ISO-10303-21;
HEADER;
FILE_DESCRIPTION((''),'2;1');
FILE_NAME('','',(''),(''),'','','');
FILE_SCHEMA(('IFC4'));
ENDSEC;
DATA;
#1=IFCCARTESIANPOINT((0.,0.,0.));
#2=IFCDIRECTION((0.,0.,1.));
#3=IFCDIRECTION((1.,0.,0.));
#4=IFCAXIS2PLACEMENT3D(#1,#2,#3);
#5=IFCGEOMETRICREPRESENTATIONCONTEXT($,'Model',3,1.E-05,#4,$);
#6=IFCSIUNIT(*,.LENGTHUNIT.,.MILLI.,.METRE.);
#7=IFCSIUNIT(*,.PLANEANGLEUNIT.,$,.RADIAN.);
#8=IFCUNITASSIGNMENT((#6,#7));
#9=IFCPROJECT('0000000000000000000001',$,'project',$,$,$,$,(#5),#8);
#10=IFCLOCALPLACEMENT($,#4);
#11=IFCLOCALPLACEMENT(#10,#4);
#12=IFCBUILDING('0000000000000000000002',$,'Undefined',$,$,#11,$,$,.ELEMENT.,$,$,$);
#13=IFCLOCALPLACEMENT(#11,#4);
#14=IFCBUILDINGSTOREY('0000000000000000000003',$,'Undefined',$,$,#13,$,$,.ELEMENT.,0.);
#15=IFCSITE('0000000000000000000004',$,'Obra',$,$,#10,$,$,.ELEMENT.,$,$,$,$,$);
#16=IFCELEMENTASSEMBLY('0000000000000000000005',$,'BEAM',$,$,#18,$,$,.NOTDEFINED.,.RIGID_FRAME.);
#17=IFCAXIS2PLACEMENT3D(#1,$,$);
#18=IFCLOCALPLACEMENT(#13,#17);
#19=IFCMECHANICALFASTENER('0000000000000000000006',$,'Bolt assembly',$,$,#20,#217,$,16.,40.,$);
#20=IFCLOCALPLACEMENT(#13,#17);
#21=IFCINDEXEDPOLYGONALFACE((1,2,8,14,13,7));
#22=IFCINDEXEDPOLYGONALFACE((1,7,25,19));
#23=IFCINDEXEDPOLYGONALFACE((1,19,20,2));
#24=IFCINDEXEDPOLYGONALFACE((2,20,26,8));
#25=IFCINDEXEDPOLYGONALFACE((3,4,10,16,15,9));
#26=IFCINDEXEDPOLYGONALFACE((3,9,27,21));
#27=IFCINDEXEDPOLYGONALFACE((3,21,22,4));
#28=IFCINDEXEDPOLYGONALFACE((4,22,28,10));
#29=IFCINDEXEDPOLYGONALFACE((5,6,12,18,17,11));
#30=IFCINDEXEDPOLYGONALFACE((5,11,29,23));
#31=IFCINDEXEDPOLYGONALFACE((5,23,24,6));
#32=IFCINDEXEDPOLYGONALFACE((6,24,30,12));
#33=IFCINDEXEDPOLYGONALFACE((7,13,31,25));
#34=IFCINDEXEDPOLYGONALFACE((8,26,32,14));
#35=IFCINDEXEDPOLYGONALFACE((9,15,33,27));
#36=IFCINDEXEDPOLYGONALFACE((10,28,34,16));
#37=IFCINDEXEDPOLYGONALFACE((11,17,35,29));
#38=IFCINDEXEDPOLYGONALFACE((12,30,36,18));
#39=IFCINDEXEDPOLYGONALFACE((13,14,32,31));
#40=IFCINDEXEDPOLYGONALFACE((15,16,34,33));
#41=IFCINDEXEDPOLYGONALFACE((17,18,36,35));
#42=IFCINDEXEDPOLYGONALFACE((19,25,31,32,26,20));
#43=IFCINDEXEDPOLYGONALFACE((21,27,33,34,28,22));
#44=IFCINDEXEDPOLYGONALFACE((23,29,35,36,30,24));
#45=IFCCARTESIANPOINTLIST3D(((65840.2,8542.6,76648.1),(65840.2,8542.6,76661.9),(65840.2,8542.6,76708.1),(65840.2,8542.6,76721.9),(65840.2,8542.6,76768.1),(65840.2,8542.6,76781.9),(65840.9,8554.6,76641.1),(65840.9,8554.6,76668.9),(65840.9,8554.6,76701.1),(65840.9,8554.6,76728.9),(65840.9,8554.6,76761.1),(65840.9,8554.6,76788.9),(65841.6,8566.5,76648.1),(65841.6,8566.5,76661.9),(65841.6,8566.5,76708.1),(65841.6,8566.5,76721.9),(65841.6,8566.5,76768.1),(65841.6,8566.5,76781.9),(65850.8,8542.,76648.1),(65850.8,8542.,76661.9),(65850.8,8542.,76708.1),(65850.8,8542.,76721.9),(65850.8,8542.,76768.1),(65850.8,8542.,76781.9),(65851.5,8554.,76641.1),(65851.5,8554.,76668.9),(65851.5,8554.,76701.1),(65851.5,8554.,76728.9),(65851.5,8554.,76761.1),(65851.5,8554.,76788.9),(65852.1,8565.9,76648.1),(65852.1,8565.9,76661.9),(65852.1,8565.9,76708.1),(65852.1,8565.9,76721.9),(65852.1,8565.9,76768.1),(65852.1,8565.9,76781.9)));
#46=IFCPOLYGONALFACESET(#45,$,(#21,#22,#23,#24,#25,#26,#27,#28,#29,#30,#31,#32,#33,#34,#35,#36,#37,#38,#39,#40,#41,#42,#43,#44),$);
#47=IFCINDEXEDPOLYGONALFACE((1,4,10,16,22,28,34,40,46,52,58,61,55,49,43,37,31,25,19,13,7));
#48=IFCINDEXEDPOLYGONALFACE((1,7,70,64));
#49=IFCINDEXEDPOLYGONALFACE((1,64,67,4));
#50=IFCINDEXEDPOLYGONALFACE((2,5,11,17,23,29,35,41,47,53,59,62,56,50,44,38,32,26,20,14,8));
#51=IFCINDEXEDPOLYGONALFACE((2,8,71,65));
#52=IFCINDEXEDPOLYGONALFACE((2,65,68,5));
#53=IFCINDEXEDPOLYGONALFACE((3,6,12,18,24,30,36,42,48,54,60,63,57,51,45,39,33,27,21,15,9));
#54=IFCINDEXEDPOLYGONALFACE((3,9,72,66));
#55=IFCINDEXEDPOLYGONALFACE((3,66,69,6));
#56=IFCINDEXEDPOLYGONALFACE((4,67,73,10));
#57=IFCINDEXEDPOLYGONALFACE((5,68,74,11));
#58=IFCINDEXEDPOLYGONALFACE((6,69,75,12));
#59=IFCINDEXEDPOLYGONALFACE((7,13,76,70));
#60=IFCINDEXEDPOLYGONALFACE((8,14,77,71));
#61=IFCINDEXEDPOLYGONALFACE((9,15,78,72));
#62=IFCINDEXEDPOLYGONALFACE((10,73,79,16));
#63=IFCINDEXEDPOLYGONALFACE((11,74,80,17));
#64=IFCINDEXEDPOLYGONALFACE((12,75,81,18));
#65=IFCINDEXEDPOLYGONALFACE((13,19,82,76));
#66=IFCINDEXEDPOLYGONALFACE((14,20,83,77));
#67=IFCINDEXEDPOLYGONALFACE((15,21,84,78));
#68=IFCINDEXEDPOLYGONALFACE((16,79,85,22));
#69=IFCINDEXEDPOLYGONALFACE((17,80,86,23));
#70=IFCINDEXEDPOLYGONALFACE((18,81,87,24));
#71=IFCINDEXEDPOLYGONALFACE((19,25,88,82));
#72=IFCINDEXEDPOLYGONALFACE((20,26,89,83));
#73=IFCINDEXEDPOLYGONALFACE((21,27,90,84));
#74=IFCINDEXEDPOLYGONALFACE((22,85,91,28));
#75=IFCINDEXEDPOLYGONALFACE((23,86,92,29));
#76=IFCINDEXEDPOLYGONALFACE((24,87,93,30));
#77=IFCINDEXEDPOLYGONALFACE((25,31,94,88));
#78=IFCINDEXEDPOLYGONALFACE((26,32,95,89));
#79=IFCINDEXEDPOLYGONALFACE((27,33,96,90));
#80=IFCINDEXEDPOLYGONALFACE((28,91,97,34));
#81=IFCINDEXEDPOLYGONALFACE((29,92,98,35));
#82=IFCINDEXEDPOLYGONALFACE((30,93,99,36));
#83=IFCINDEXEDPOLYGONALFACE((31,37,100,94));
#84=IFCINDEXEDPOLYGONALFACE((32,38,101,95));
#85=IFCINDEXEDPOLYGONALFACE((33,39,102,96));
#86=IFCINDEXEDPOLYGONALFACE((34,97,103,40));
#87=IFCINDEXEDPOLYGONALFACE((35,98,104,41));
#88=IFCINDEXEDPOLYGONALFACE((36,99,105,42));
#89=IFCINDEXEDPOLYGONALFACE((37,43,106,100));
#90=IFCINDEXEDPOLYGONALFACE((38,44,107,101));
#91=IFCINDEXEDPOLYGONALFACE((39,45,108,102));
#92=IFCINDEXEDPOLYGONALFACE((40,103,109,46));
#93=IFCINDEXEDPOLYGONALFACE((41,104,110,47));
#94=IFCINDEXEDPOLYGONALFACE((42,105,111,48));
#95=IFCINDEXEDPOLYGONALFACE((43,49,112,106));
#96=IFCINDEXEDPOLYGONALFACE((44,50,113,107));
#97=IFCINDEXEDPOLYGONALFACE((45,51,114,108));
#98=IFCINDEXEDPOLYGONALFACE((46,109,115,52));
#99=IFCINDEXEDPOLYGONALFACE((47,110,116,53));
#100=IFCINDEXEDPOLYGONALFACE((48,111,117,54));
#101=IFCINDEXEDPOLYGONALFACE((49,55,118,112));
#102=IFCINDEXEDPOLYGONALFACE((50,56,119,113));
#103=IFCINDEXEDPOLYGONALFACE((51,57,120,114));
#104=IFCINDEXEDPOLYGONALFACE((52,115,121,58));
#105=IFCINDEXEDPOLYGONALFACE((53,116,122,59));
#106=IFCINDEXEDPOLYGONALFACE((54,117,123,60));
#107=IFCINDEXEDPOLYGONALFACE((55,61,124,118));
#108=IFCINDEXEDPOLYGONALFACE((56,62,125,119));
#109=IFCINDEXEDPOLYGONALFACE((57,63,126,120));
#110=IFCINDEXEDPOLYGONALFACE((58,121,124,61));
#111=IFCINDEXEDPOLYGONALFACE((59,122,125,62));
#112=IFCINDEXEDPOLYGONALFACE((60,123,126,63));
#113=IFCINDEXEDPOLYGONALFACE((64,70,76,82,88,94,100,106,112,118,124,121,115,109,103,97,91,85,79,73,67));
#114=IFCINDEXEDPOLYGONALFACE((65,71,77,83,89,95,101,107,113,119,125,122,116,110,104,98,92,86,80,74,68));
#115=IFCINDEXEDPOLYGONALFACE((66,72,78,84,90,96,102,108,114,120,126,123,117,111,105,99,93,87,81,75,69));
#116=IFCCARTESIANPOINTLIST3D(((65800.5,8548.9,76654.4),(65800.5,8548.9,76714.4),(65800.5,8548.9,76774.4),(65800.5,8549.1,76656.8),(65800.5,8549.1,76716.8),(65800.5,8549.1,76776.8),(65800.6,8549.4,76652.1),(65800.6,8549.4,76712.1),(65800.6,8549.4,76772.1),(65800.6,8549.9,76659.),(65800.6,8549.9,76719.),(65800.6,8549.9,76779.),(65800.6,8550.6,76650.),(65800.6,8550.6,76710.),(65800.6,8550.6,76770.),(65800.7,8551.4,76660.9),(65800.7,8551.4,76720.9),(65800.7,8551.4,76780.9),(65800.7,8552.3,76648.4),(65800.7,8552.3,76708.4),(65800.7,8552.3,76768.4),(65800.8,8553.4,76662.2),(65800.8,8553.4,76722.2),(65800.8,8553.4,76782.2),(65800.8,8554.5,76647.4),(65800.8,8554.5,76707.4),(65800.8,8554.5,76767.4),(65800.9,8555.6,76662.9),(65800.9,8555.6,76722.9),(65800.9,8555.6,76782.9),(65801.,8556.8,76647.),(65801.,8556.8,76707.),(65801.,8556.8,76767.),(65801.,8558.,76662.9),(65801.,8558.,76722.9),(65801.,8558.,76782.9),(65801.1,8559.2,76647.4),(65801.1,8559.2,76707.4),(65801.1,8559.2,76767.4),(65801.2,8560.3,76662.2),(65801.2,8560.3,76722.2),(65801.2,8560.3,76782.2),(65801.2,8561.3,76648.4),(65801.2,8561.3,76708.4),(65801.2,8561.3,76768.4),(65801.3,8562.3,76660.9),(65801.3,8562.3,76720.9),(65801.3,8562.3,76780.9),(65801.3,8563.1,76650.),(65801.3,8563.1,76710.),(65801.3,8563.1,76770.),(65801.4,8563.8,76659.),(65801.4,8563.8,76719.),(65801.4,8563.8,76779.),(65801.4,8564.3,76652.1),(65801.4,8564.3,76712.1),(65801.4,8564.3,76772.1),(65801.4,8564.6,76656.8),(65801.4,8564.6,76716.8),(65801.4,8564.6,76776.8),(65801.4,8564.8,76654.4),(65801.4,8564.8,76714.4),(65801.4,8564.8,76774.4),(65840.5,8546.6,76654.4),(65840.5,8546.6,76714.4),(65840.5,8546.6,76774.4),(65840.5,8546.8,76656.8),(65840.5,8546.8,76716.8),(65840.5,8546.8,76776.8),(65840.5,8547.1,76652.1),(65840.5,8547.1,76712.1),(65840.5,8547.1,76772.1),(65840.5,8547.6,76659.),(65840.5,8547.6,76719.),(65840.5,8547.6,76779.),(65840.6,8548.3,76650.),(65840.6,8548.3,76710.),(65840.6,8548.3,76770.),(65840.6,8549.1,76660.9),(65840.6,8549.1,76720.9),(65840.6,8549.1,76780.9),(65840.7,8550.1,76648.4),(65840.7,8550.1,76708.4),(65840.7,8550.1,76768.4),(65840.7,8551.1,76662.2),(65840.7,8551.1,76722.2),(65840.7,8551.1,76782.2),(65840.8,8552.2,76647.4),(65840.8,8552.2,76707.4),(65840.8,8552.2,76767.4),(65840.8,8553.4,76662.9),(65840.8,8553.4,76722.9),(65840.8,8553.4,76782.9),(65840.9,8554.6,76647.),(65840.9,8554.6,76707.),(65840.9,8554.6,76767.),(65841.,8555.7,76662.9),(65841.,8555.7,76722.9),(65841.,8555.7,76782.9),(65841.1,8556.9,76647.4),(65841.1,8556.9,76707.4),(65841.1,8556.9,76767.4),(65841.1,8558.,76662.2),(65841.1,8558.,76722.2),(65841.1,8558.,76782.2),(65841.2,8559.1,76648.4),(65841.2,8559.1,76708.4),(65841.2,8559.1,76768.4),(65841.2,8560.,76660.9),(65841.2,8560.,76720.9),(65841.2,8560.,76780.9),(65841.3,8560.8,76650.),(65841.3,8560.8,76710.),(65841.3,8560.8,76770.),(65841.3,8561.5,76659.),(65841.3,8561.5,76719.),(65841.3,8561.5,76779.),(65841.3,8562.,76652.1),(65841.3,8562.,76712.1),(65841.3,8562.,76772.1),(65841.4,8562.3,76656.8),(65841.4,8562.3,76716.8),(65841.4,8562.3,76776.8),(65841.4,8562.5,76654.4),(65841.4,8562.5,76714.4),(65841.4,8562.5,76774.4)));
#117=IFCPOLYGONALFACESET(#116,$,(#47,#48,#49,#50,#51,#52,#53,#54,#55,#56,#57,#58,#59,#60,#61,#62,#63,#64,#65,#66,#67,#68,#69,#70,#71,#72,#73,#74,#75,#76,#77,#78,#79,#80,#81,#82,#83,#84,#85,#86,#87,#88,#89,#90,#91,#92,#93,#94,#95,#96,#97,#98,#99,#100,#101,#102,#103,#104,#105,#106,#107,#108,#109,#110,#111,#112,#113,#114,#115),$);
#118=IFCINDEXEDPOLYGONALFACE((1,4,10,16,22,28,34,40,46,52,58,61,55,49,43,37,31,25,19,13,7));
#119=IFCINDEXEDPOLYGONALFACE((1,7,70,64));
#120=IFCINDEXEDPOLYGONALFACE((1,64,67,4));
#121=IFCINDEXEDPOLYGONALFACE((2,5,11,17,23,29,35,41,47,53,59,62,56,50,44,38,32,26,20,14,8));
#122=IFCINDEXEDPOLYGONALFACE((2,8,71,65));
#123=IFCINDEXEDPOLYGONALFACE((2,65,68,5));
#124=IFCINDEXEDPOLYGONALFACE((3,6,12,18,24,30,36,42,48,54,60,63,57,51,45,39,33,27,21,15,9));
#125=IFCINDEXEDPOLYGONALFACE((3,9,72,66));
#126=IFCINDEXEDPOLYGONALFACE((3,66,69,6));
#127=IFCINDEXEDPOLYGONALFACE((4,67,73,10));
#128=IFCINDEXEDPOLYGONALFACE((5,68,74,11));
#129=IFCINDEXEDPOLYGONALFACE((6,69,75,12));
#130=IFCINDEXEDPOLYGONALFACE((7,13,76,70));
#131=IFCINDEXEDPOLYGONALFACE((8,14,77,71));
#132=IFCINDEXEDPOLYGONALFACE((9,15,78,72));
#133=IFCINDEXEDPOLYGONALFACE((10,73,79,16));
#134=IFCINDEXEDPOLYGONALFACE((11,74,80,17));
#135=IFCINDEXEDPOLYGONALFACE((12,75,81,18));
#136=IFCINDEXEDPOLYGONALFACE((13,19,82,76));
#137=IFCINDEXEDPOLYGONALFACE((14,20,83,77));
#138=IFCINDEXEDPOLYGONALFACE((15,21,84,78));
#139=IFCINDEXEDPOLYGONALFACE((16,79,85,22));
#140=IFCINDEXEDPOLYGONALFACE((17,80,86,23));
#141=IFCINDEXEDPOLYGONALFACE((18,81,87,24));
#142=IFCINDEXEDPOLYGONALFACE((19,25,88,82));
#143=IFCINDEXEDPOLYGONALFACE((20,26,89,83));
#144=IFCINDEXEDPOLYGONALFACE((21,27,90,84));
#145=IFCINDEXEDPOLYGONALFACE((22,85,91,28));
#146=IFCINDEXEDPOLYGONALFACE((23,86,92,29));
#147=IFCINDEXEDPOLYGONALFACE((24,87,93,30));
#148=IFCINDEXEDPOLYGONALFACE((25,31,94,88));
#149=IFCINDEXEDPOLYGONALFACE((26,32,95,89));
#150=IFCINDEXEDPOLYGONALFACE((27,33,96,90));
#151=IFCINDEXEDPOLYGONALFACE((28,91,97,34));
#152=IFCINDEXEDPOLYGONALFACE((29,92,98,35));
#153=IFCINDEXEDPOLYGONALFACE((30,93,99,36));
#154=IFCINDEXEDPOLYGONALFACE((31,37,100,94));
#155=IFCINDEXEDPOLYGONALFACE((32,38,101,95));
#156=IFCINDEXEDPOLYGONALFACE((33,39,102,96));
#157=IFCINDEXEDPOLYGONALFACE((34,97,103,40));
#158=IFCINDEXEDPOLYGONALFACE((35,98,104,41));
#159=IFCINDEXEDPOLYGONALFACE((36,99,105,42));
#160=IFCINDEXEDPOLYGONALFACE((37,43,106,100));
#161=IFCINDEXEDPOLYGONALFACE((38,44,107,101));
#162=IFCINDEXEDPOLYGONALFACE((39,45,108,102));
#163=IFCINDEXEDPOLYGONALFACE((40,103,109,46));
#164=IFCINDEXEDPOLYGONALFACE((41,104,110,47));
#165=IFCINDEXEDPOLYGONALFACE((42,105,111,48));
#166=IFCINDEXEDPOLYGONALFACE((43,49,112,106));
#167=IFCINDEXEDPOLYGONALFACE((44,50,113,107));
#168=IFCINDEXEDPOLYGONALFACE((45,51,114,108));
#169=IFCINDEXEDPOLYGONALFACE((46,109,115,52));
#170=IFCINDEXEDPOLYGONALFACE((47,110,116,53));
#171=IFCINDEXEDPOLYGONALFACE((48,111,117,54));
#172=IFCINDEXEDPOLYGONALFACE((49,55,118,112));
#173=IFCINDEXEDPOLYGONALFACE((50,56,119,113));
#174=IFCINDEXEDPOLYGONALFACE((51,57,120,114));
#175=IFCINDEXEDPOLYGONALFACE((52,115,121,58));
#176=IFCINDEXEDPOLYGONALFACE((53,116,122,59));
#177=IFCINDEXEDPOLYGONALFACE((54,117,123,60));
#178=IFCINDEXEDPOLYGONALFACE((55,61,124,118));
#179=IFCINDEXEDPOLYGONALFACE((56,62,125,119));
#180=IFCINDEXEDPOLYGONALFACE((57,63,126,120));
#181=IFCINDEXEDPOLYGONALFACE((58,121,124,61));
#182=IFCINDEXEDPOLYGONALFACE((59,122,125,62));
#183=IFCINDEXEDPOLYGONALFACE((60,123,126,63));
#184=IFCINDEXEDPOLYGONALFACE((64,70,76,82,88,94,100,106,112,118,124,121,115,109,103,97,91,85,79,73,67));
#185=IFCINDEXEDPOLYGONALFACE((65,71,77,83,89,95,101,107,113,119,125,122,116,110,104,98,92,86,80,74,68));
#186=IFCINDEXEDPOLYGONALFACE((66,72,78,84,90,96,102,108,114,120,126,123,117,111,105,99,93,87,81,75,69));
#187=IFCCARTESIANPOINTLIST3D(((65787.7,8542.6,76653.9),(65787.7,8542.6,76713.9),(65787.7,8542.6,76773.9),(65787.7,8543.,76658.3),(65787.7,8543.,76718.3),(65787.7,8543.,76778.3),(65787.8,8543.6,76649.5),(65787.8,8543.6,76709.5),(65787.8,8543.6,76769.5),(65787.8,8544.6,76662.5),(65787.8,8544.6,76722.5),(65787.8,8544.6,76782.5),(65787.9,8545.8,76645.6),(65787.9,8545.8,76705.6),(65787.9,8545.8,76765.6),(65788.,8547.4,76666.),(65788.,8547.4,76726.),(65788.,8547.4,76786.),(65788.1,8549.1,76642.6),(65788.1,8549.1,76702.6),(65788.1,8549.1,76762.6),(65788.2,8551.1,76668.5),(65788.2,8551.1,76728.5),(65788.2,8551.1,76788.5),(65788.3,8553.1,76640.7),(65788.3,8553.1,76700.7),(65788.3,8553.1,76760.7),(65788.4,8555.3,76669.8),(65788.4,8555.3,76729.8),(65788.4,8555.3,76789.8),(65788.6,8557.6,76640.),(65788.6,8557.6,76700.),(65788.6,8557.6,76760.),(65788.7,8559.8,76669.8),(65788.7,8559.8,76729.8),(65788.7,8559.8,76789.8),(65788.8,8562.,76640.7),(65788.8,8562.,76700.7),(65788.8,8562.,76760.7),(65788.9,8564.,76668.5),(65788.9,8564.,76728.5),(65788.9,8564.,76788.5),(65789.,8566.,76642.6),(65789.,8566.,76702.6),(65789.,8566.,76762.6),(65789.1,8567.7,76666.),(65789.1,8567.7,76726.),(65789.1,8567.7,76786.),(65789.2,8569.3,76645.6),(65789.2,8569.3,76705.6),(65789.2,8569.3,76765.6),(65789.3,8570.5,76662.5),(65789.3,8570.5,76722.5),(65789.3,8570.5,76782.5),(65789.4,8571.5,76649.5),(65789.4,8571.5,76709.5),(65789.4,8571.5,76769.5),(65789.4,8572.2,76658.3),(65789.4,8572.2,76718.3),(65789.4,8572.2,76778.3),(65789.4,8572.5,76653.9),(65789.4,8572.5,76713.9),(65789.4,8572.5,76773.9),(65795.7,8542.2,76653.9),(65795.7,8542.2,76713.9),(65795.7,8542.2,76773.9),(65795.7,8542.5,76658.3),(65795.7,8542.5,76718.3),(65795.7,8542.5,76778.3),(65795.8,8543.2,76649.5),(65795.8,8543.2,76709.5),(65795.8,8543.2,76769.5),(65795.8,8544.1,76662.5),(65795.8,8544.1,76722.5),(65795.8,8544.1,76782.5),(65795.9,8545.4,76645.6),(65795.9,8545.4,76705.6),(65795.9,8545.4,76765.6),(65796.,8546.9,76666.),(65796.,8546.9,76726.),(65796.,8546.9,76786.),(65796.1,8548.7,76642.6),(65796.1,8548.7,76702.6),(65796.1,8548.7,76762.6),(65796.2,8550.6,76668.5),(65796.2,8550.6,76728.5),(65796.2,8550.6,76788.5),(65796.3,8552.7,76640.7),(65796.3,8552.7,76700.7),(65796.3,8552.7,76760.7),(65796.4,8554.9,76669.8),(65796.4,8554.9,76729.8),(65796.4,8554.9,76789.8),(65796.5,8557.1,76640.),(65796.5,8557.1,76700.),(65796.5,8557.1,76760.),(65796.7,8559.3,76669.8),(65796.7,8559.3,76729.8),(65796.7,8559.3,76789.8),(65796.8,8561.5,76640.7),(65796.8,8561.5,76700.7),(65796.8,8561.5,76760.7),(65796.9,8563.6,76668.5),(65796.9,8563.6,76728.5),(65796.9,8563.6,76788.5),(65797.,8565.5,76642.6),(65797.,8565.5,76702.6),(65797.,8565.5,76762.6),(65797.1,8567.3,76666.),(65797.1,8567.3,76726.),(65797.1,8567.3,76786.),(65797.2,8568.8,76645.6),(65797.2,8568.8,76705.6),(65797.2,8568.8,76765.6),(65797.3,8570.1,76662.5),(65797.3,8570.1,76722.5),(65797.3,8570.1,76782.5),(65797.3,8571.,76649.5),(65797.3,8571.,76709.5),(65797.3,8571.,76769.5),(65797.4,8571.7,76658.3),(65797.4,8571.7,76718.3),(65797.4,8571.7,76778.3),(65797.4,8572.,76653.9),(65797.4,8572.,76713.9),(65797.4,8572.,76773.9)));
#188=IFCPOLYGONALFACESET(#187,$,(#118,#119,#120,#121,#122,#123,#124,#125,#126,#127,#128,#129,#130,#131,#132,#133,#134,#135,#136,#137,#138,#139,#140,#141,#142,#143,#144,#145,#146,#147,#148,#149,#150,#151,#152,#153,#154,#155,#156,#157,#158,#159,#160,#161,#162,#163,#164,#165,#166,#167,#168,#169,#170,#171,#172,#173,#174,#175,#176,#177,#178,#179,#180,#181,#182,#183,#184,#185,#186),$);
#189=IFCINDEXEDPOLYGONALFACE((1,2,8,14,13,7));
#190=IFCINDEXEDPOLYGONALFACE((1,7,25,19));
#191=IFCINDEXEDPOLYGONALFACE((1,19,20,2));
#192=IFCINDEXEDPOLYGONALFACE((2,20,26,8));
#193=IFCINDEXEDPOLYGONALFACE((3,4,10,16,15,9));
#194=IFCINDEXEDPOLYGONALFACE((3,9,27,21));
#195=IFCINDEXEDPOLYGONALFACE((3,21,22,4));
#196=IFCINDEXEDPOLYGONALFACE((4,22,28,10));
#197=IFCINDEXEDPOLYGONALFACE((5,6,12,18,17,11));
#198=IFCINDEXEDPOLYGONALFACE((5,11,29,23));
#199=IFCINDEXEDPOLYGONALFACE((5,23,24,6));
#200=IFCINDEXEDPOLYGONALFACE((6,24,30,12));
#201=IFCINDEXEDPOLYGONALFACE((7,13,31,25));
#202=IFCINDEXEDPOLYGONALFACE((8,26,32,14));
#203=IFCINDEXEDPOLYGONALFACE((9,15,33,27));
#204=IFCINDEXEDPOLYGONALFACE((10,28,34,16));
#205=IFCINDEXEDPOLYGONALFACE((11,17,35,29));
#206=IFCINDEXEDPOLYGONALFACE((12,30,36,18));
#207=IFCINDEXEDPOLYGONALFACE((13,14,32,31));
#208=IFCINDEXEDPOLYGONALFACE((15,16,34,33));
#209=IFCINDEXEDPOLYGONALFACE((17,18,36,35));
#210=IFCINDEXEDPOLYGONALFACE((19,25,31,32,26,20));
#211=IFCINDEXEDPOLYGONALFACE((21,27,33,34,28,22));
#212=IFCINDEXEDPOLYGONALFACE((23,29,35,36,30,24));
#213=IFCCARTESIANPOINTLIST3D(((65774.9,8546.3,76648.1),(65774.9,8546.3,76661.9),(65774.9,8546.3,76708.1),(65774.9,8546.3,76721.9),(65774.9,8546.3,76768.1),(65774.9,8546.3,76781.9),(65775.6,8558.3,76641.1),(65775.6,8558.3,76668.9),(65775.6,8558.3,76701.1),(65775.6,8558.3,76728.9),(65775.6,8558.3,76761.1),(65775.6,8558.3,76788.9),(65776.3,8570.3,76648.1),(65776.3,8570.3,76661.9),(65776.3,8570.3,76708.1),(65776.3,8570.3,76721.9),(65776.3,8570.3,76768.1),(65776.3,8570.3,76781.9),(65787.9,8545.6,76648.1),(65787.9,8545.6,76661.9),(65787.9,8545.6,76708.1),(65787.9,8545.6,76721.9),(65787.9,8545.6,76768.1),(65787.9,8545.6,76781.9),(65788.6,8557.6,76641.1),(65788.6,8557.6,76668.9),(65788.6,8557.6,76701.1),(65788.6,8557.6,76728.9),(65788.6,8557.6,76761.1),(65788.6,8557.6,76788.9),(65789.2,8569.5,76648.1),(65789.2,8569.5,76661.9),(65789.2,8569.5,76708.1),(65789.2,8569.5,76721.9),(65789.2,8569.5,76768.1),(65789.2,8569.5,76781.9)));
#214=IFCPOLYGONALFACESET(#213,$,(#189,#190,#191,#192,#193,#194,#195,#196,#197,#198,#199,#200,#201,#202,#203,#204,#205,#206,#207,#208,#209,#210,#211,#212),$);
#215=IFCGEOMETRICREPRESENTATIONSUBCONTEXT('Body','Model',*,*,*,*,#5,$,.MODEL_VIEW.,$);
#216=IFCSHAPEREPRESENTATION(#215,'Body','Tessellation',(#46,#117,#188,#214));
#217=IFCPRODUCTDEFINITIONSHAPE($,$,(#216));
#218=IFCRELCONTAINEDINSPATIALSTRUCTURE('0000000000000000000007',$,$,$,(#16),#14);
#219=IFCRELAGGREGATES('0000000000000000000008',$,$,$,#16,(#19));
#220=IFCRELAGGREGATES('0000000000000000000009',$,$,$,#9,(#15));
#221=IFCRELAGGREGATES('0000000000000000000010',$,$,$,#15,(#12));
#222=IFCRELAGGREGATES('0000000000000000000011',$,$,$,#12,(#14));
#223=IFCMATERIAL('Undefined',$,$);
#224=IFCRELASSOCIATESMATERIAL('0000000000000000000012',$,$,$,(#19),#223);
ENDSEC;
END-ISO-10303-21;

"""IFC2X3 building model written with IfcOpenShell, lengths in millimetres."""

from ifc_helpers import new_model, si_unit, frame, origin_with_axes, origin_2d_with_axis, place, context, subcontext, project, spatial, polyline, circle, outline, extrude, source, transform, mapped, material, element, aggregate, save


model = new_model("IFC2X3")

# Units and contexts
model_context = context("Model", 3, precision=1e-05, world=origin_with_axes())
body_context = subcontext(model_context, "Body", "Model", "MODEL_VIEW")
ifc_project = project(units=[si_unit("LENGTHUNIT", "METRE", prefix="MILLI"), si_unit("PLANEANGLEUNIT", "RADIAN")], contexts=[model_context])

# Site, building, storey
site_placement = place(None, origin_with_axes())
site = spatial("IfcSite", under=ifc_project, at=site_placement, Name="Obra", CompositionType="ELEMENT")
building_placement = place(site_placement, origin_with_axes())
building = spatial("IfcBuilding", under=site, at=building_placement, Name="Undefined", CompositionType="ELEMENT")
storey_placement = place(building_placement, origin_with_axes())
storey = spatial("IfcBuildingStorey", under=building, at=storey_placement, Name="Undefined", CompositionType="ELEMENT", Elevation=0.0)

# Shared definitions
ifc_material_1 = material(Name="Undefined")
shared_shape_1 = source(origin_with_axes(), body_context, "Body", "SweptSolid", [
    extrude(outline(polyline([(13.9, 0.0), (6.9, 12.0), (-6.9, 12.0), (-13.9, 0.0), (-6.9, -12.0), (6.9, -12.0), (13.9, 0.0)])), frame((0.0, -19.7, 0.0), z_axis=(0.0, 1.0, 0.0), x_axis=(1.0, 0.0, 0.0)), (0.0, 0.0, 1.0), 10.6),
    extrude(circle(Radius=8.0, at=origin_2d_with_axis()), frame((0.0, -9.1, 0.0), z_axis=(0.0, 1.0, 0.0), x_axis=(1.0, 0.0, 0.0)), (0.0, 0.0, 1.0), 40.0),
    extrude(circle(Radius=15.0, at=origin_2d_with_axis()), frame((0.0, 35.3, 0.0), z_axis=(0.0, 1.0, 0.0), x_axis=(1.0, 0.0, 0.0)), (0.0, 0.0, 1.0), 8.0),
    extrude(outline(polyline([(13.9, 0.0), (6.9, 12.0), (-6.9, 12.0), (-13.9, 0.0), (-6.9, -12.0), (6.9, -12.0), (13.9, 0.0)])), frame((0.0, 43.3, 0.0), z_axis=(0.0, 1.0, 0.0), x_axis=(1.0, 0.0, 0.0)), (0.0, 0.0, 1.0), 13.0),
])

# Element assembly, mechanical fastener
assembly_1_placement = place(storey_placement, origin_with_axes())
assembly_1 = element("IfcElementAssembly", 1, at=assembly_1_placement, inside=storey, Name="BEAM", AssemblyPlace="NOTDEFINED", PredefinedType="RIGID_FRAME")
mechanical_fastener_1_placement = place(assembly_1_placement, frame((65829.0, 8505.2, 76835.0), z_axis=(0.05711, 0.998368, 0.0), x_axis=(0.0, 0.0, -1.0)))
mechanical_fastener_1 = element("IfcMechanicalFastener", 2, at=mechanical_fastener_1_placement, material=ifc_material_1, Name="Bolt assembly", NominalDiameter=16.0, NominalLength=40.0, context=body_context, shape_type="MappedRepresentation", body=[
    mapped(shared_shape_1, transform((60.0, 0.0, 50.0))),
    mapped(shared_shape_1, transform((120.0, 0.0, 50.0))),
    mapped(shared_shape_1, transform((180.0, 0.0, 50.0))),
])
aggregate(assembly_1, [mechanical_fastener_1])

save(model, "model.ifc")
